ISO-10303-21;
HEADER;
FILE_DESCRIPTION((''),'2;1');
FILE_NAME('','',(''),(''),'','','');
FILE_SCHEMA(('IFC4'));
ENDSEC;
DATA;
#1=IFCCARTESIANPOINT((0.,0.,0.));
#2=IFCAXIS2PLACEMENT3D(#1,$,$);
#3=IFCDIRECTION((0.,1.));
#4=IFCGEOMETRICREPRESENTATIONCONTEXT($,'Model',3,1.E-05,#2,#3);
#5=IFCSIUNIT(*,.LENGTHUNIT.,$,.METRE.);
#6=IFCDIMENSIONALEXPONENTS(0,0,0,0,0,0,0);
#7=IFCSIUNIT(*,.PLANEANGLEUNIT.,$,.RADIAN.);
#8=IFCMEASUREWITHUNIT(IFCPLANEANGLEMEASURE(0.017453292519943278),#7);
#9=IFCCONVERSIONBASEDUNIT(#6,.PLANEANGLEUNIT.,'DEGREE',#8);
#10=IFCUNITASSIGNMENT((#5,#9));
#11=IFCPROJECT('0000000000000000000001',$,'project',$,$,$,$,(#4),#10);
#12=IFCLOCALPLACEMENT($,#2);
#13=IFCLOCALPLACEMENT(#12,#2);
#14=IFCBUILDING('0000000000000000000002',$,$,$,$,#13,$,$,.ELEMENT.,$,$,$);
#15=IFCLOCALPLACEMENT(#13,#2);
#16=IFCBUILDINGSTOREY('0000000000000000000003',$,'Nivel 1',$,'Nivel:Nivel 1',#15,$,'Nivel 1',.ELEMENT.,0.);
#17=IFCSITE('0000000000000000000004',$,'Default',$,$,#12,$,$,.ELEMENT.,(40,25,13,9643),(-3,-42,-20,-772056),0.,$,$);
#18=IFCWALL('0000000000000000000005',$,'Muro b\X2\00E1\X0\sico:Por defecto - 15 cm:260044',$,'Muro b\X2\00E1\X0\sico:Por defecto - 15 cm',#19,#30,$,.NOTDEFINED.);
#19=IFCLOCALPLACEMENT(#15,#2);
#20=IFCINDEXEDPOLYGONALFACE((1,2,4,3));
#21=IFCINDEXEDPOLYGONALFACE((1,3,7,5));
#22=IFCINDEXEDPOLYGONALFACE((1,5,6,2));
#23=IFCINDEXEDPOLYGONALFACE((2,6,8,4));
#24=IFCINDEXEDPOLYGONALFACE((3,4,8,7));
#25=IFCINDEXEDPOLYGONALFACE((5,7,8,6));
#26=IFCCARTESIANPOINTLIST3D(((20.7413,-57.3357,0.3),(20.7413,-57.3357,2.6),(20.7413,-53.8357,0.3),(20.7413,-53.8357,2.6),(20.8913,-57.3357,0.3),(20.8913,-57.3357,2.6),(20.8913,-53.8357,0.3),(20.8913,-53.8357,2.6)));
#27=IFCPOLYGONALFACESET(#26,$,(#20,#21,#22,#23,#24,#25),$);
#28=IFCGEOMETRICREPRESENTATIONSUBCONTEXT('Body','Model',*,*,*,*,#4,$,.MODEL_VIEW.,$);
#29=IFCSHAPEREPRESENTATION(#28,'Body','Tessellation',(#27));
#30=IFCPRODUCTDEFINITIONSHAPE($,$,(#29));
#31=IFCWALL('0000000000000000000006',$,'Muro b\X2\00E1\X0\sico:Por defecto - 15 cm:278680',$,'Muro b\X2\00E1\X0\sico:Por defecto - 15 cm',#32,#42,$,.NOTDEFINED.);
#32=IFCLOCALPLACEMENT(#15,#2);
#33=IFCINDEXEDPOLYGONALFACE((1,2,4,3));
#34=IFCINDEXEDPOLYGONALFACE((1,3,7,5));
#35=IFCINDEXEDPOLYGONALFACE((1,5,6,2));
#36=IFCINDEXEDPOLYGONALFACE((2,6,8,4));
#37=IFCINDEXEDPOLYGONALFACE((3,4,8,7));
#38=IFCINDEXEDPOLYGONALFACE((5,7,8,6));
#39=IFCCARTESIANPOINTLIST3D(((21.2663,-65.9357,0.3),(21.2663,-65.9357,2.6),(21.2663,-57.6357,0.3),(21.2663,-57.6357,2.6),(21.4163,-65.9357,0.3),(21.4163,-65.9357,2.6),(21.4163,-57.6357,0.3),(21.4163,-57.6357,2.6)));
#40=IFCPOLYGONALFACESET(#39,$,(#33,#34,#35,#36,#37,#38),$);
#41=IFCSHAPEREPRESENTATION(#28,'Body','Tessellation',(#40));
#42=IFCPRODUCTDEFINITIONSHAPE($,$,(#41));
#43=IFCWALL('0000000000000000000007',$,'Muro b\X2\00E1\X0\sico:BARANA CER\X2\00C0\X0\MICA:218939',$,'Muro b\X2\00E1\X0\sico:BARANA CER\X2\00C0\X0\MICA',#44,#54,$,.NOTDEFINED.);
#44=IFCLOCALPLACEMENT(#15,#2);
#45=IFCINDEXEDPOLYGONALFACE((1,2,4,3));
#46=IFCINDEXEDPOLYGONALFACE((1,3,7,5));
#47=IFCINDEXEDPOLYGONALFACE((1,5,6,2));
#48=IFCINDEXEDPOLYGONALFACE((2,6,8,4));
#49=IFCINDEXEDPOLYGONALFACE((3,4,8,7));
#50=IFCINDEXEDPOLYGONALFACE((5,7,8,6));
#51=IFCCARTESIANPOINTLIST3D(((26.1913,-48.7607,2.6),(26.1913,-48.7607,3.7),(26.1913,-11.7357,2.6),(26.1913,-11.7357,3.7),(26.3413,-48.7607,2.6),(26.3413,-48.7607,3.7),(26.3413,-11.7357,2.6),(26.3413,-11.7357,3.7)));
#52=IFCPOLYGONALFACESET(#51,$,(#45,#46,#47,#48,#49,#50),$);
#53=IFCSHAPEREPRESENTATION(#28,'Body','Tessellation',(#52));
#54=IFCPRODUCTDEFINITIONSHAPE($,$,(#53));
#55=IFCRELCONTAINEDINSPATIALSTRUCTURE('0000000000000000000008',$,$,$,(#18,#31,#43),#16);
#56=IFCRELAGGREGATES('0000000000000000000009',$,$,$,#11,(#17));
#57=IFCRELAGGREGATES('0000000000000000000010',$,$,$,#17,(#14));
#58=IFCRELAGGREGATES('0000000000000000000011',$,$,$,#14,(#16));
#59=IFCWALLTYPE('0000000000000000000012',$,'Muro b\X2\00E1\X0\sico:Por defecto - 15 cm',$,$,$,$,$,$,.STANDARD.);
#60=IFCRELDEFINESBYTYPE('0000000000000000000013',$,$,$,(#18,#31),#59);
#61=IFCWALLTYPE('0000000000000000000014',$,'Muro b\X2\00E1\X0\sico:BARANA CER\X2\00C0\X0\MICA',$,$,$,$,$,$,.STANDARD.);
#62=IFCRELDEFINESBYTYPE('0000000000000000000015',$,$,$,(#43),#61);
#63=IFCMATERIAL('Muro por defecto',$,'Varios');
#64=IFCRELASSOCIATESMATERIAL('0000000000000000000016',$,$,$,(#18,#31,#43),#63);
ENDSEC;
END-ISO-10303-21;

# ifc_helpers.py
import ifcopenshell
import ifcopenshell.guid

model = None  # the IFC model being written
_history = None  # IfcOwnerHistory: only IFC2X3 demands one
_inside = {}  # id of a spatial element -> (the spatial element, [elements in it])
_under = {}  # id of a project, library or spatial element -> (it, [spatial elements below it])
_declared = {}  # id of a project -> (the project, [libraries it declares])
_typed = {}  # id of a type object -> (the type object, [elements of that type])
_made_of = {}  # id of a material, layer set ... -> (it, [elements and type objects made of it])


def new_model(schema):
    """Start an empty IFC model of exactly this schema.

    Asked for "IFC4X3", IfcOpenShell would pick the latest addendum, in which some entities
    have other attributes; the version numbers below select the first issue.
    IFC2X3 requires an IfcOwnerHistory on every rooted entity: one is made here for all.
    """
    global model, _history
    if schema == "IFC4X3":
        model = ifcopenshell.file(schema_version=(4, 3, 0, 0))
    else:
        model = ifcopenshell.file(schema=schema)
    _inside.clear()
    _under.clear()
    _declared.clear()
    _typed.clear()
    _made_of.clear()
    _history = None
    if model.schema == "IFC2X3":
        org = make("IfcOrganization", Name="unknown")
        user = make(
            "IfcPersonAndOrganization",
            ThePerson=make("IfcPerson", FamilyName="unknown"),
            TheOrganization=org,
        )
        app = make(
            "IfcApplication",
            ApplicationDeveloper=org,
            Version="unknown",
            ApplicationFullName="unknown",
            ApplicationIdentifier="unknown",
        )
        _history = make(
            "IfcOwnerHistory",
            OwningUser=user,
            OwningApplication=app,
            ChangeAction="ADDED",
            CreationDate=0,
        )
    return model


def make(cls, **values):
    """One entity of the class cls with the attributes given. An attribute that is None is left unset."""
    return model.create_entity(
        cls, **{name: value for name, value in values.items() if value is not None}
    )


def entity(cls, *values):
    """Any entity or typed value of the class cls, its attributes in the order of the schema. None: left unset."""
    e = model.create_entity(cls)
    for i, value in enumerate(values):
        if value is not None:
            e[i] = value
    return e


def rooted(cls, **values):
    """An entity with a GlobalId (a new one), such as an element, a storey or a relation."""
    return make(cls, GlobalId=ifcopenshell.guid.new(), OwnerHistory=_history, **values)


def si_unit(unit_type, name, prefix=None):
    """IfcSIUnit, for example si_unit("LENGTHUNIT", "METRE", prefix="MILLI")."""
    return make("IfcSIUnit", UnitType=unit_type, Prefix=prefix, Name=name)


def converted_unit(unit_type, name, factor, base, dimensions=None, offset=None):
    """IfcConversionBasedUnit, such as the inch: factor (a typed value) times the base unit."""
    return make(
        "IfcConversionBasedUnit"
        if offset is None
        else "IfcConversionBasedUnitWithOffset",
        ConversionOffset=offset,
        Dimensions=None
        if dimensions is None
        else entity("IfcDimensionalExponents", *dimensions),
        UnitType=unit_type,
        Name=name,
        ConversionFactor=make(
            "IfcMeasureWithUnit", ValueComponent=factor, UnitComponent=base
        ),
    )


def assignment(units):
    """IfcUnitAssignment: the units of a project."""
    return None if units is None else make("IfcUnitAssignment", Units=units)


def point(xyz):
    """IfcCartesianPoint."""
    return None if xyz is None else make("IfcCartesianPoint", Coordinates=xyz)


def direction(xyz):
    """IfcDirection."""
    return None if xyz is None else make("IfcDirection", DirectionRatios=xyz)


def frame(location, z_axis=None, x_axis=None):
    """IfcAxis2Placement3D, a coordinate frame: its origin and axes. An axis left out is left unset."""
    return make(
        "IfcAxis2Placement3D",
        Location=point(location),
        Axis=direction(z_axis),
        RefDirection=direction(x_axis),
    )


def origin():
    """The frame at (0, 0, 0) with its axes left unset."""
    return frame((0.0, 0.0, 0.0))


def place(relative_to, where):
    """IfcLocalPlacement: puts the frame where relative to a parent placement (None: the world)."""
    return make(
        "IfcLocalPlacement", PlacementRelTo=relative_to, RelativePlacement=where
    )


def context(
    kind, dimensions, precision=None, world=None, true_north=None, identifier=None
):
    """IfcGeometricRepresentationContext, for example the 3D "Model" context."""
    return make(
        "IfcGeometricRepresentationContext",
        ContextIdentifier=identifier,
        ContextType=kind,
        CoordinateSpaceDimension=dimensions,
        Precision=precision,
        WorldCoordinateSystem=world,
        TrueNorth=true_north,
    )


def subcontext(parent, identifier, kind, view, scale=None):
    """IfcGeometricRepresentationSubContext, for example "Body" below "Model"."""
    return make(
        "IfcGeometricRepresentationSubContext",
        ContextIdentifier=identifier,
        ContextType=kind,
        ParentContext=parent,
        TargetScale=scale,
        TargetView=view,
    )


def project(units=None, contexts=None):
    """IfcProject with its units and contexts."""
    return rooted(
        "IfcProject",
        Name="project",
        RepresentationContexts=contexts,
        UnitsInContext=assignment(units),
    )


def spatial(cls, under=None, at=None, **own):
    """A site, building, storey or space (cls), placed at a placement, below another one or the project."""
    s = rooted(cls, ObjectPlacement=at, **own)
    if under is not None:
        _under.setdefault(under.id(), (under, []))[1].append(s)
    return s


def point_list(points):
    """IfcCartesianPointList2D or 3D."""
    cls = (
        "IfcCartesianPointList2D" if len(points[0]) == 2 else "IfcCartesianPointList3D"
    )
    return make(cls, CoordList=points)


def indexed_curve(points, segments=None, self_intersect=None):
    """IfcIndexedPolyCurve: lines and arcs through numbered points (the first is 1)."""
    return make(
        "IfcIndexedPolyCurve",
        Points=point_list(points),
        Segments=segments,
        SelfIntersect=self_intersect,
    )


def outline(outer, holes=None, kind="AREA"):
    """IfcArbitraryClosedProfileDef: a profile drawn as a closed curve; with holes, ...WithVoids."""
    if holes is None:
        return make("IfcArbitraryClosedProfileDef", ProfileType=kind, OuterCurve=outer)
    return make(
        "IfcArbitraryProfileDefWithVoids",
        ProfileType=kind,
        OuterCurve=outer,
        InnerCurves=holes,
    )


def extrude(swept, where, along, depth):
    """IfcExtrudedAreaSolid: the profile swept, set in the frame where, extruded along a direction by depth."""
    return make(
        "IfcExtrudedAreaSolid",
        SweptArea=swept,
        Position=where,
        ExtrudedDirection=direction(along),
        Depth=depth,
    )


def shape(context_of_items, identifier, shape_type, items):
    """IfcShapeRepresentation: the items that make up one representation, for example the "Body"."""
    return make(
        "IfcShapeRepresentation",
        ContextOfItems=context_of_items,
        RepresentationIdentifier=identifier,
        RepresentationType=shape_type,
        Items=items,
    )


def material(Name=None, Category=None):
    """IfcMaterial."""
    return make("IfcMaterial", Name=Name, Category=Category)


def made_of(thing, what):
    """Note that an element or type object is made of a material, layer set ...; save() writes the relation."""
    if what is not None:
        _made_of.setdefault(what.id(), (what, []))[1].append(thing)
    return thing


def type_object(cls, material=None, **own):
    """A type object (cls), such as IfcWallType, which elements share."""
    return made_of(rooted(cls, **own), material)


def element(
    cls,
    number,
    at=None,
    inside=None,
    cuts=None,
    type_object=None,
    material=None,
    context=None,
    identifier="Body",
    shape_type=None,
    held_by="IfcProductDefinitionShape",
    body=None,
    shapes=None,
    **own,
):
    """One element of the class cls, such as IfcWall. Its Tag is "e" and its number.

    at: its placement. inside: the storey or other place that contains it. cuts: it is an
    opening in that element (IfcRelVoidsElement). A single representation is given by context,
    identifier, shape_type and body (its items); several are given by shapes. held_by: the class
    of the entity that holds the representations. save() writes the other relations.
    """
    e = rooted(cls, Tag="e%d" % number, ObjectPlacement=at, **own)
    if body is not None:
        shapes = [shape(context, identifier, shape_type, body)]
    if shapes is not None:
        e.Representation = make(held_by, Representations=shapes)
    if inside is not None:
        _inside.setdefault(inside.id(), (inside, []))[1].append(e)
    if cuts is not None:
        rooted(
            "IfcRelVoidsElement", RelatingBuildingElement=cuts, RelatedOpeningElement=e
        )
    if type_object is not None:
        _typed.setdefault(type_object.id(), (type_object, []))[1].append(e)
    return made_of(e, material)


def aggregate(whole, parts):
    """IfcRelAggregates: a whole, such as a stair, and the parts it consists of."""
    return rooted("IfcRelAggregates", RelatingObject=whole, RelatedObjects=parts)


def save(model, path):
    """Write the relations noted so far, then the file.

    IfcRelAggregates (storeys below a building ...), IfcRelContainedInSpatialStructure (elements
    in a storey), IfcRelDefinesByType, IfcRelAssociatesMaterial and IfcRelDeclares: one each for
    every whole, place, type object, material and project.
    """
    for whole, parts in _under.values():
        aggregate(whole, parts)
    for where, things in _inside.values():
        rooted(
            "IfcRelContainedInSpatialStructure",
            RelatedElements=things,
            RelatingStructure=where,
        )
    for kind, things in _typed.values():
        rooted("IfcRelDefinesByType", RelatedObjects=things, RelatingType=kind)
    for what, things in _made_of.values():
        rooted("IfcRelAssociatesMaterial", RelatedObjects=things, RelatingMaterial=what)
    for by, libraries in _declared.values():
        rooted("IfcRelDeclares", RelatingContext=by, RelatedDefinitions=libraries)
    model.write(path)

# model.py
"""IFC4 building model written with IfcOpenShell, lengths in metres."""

from ifc_helpers import new_model, entity, si_unit, converted_unit, direction, frame, origin, place, context, subcontext, project, spatial, indexed_curve, outline, extrude, material, type_object, element, save


model = new_model("IFC4")

# Units and contexts
model_context = context("Model", 3, precision=1e-05, world=origin(), true_north=direction((0.0, 1.0)))
body_context = subcontext(model_context, "Body", "Model", "MODEL_VIEW")
ifc_project = project(units=[si_unit("LENGTHUNIT", "METRE"), converted_unit("PLANEANGLEUNIT", "DEGREE", entity("IfcPlaneAngleMeasure", 0.017453292519943278), si_unit("PLANEANGLEUNIT", "RADIAN"), dimensions=[0, 0, 0, 0, 0, 0, 0])], contexts=[model_context])

# Site, building, storey
site_placement = place(None, origin())
site = spatial("IfcSite", under=ifc_project, at=site_placement, Name="Default", CompositionType="ELEMENT", RefLatitude=(40, 25, 13, 9643), RefLongitude=(-3, -42, -20, -772056), RefElevation=0.0)
building_placement = place(site_placement, origin())
building = spatial("IfcBuilding", under=site, at=building_placement, CompositionType="ELEMENT")
storey_placement = place(building_placement, origin())
storey = spatial("IfcBuildingStorey", under=building, at=storey_placement, Name="Nivel 1", ObjectType="Nivel:Nivel 1", LongName="Nivel 1", CompositionType="ELEMENT", Elevation=0.0)

# Shared definitions
ifc_material = material(Name="Muro por defecto", Category="Varios")
wall_type_1 = type_object("IfcWallType", Name="Muro básico:Por defecto - 15 cm", PredefinedType="STANDARD")

# Walls
wall_1_placement = place(storey_placement, frame((20.8163, -57.3357, 0.3), z_axis=(0.0, 0.0, 1.0), x_axis=(0.0, 1.0, 0.0)))
element("IfcWall", 1, at=wall_1_placement, inside=storey, type_object=wall_type_1, material=ifc_material, Name="Muro básico:Por defecto - 15 cm:260044", ObjectType="Muro básico:Por defecto - 15 cm", PredefinedType="NOTDEFINED", context=body_context, shape_type="SweptSolid", body=[
    extrude(outline(indexed_curve([(3.5, 0.075), (0.0, 0.075), (0.0, -0.075), (3.5, -0.075), (3.5, 0.075)], self_intersect=False)), origin(), (0.0, 0.0, 1.0), 2.3),
])
wall_2_placement = place(storey_placement, frame((21.3413, -57.6357, 0.3), z_axis=(0.0, 0.0, 1.0), x_axis=(0.0, -1.0, 0.0)))
element("IfcWall", 2, at=wall_2_placement, inside=storey, type_object=wall_type_1, material=ifc_material, Name="Muro básico:Por defecto - 15 cm:278680", ObjectType="Muro básico:Por defecto - 15 cm", PredefinedType="NOTDEFINED", context=body_context, shape_type="SweptSolid", body=[
    extrude(outline(indexed_curve([(8.3, 0.075), (0.0, 0.075), (0.0, -0.075), (8.3, -0.075), (8.3, 0.075)], self_intersect=False)), origin(), (0.0, 0.0, 1.0), 2.3),
])
wall_type_2 = type_object("IfcWallType", Name="Muro básico:BARANA CERÀMICA", PredefinedType="STANDARD")
wall_3_placement = place(storey_placement, frame((26.2663, -11.7357, 2.6), z_axis=(0.0, 0.0, 1.0), x_axis=(0.0, -1.0, 0.0)))
element("IfcWall", 3, at=wall_3_placement, inside=storey, type_object=wall_type_2, material=ifc_material, Name="Muro básico:BARANA CERÀMICA:218939", ObjectType="Muro básico:BARANA CERÀMICA", PredefinedType="NOTDEFINED", context=body_context, shape_type="SweptSolid", body=[
    extrude(outline(indexed_curve([(37.025, 0.075), (0.0, 0.075), (0.0, -0.075), (37.025, -0.075), (37.025, 0.075)], self_intersect=False)), origin(), (0.0, 0.0, 1.0), 1.1),
])

save(model, "model.ifc")
